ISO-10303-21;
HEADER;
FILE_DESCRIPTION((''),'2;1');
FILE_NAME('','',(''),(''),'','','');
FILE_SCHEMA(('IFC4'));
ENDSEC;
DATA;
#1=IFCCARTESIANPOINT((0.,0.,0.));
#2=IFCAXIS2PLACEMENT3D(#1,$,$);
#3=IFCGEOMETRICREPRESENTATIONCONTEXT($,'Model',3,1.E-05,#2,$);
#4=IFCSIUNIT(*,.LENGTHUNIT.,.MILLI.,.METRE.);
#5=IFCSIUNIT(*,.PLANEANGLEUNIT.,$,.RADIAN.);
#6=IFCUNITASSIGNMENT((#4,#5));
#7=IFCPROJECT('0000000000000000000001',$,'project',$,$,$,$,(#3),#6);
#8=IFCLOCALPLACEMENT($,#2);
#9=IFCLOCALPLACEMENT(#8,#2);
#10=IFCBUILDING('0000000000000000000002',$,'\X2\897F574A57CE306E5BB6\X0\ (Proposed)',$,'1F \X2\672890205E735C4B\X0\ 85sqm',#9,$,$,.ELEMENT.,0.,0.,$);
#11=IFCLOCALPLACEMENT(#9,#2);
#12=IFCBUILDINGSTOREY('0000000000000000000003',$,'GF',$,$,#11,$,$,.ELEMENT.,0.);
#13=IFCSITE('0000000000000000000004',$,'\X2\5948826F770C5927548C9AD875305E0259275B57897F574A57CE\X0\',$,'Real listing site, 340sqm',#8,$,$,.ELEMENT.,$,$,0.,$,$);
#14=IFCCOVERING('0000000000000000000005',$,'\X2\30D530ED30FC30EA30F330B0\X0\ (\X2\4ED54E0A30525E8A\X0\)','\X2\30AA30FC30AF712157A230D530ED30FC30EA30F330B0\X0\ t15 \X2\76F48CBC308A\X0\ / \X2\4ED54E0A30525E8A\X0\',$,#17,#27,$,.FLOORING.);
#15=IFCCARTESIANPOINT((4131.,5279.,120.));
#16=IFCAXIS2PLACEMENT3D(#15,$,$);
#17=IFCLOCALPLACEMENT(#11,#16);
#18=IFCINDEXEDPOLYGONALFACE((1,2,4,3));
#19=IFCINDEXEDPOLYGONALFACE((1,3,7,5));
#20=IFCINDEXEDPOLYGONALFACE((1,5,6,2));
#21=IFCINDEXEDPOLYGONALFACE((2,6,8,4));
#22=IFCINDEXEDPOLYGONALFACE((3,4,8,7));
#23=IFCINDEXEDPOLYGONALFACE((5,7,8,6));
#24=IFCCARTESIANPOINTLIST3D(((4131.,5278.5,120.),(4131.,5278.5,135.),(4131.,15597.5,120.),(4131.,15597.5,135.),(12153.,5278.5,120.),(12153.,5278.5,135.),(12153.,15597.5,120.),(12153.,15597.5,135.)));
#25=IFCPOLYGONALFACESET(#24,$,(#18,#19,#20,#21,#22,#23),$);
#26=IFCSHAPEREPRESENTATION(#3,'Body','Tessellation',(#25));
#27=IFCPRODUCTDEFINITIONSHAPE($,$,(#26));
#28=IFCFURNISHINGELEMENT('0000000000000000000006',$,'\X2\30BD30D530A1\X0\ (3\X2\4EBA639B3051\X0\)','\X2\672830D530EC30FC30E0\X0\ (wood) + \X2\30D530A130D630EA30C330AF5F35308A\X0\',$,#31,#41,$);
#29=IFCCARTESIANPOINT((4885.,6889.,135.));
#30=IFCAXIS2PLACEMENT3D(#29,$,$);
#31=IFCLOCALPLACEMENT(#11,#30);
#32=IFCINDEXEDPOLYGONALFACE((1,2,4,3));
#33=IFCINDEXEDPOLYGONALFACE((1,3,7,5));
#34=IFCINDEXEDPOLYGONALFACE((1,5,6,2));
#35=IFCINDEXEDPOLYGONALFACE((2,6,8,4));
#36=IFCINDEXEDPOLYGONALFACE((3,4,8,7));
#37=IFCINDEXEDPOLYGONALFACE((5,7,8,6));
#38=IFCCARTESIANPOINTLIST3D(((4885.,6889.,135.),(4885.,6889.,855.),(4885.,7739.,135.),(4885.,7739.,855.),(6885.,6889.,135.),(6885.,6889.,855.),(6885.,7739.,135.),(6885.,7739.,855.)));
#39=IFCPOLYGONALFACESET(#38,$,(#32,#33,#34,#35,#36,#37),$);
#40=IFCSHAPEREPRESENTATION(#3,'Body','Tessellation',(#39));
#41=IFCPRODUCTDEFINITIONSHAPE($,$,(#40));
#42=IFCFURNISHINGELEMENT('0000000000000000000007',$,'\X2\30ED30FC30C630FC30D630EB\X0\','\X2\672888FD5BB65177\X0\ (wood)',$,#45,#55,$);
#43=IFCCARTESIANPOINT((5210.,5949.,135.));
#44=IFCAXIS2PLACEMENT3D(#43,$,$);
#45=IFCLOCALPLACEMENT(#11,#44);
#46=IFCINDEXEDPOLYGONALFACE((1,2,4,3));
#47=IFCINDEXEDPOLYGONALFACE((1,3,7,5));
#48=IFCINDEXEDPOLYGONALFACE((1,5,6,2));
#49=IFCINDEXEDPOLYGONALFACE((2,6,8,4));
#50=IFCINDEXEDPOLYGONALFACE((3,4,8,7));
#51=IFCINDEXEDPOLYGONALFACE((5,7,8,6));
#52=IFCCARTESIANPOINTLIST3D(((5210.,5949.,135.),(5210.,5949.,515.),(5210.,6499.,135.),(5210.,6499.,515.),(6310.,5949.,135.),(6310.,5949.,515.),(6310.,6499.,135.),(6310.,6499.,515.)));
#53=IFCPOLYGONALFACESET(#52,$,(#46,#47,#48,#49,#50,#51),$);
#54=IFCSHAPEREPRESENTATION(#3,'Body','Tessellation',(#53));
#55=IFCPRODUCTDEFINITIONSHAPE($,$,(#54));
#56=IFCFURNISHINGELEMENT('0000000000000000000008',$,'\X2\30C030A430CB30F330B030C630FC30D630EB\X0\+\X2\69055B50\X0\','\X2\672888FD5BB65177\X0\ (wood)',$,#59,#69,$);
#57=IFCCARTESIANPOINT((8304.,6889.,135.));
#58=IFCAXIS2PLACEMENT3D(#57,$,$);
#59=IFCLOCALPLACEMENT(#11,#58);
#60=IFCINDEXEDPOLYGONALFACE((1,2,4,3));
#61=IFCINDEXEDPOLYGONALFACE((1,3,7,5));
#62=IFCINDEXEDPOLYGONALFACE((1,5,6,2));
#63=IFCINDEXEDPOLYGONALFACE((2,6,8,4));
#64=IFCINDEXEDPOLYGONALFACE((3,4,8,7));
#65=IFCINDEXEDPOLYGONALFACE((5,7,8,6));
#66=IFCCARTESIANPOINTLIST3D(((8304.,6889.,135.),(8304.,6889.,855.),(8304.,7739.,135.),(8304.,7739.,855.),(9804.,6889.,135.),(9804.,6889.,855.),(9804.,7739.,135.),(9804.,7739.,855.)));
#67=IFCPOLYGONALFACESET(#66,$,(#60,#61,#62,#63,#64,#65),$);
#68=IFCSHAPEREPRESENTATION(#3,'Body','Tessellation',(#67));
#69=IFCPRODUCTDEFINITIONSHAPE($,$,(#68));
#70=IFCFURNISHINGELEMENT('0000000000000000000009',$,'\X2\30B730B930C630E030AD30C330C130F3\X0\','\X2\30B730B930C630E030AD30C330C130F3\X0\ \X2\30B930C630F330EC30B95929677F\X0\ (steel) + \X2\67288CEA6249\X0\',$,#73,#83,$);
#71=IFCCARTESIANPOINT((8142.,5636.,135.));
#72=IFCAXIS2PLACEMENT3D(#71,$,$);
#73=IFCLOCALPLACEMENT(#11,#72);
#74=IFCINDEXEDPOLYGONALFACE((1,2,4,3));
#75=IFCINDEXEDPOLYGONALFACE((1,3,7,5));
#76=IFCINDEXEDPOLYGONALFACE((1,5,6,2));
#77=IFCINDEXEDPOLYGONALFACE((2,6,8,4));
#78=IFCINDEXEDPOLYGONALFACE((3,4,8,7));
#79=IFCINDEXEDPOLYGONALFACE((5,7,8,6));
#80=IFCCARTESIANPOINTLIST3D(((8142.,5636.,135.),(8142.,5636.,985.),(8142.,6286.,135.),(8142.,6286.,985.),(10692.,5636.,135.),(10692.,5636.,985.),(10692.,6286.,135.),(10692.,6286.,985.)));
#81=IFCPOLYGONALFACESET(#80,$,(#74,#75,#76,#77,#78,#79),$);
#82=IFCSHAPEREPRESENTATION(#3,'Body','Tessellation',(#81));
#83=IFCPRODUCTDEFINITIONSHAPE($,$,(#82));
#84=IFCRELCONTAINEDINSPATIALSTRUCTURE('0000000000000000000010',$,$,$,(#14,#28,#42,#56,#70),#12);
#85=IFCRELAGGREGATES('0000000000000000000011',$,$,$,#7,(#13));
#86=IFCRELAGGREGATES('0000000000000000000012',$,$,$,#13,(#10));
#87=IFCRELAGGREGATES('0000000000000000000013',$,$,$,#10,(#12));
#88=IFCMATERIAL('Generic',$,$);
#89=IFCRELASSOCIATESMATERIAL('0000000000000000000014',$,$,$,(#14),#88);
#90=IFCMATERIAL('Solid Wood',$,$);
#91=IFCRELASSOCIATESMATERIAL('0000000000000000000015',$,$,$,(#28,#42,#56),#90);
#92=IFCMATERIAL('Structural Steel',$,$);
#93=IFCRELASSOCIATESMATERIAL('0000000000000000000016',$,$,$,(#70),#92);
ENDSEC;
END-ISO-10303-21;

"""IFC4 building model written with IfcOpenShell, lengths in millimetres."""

from ifc_helpers import new_model, si_unit, frame, frame_2d, origin, place, context, project, spatial, rectangle, extrude, material, element, save


model = new_model("IFC4")

# Units and contexts
model_context = context("Model", 3, precision=1e-05, world=origin())
ifc_project = project(units=[si_unit("LENGTHUNIT", "METRE", prefix="MILLI"), si_unit("PLANEANGLEUNIT", "RADIAN")], contexts=[model_context])

# Site, building, storey
site_placement = place(None, origin())
site = spatial("IfcSite", under=ifc_project, at=site_placement, Name="奈良県大和高田市大字西坊城", ObjectType="Real listing site, 340sqm", CompositionType="ELEMENT", RefElevation=0.0)
building_placement = place(site_placement, origin())
building = spatial("IfcBuilding", under=site, at=building_placement, Name="西坊城の家 (Proposed)", ObjectType="1F 木造平屋 85sqm", CompositionType="ELEMENT", ElevationOfRefHeight=0.0, ElevationOfTerrain=0.0)
storey_placement = place(building_placement, origin())
storey = spatial("IfcBuildingStorey", under=building, at=storey_placement, Name="GF", CompositionType="ELEMENT", Elevation=0.0)

# Shared definitions
ifc_material_1 = material(Name="Solid Wood")

# Shared definitions
ifc_material_2 = material(Name="Structural Steel")

# Covering
ifc_material_3 = material(Name="Generic")
covering_placement = place(storey_placement, frame((4131.0, 5279.0, 120.0)))
element("IfcCovering", 1, at=covering_placement, inside=storey, material=ifc_material_3, Name="フローリング (仕上げ床)", Description="オーク無垢フローリング t15 直貼り / 仕上げ床", PredefinedType="FLOORING", context=model_context, shape_type="SweptSolid", body=[
    extrude(rectangle(XDim=8022.0, YDim=10319.0, at=frame_2d((4011.0, 5159.0))), frame((4131.0, 5279.0, 120.0)), (0.0, 0.0, 1.0), 15.0),
])

# Furnishing elements
furnishing_1_placement = place(storey_placement, frame((4885.0, 6889.0, 135.0)))
element("IfcFurnishingElement", 2, at=furnishing_1_placement, inside=storey, material=ifc_material_1, Name="ソファ (3人掛け)", Description="木フレーム (wood) + ファブリック張り", context=model_context, shape_type="SweptSolid", body=[
    extrude(rectangle(XDim=2000.0, YDim=850.0, at=frame_2d((1000.0, 425.0))), frame((4885.0, 6889.0, 135.0)), (0.0, 0.0, 1.0), 720.0),
])
furnishing_2_placement = place(storey_placement, frame((5210.0, 5949.0, 135.0)))
element("IfcFurnishingElement", 3, at=furnishing_2_placement, inside=storey, material=ifc_material_1, Name="ローテーブル", Description="木製家具 (wood)", context=model_context, shape_type="SweptSolid", body=[
    extrude(rectangle(XDim=1100.0, YDim=550.0, at=frame_2d((550.0, 275.0))), frame((5210.0, 5949.0, 135.0)), (0.0, 0.0, 1.0), 380.0),
])
furnishing_3_placement = place(storey_placement, frame((8304.0, 6889.0, 135.0)))
element("IfcFurnishingElement", 4, at=furnishing_3_placement, inside=storey, material=ifc_material_1, Name="ダイニングテーブル+椅子", Description="木製家具 (wood)", context=model_context, shape_type="SweptSolid", body=[
    extrude(rectangle(XDim=1500.0, YDim=850.0, at=frame_2d((750.0, 425.0))), frame((8304.0, 6889.0, 135.0)), (0.0, 0.0, 1.0), 720.0),
])
furnishing_4_placement = place(storey_placement, frame((8142.0, 5636.0, 135.0)))
element("IfcFurnishingElement", 5, at=furnishing_4_placement, inside=storey, material=ifc_material_2, Name="システムキッチン", Description="システムキッチン ステンレス天板 (steel) + 木質扉", context=model_context, shape_type="SweptSolid", body=[
    extrude(rectangle(XDim=2550.0, YDim=650.0, at=frame_2d((1275.0, 325.0))), frame((8142.0, 5636.0, 135.0)), (0.0, 0.0, 1.0), 850.0),
])

save(model, "model.ifc")
